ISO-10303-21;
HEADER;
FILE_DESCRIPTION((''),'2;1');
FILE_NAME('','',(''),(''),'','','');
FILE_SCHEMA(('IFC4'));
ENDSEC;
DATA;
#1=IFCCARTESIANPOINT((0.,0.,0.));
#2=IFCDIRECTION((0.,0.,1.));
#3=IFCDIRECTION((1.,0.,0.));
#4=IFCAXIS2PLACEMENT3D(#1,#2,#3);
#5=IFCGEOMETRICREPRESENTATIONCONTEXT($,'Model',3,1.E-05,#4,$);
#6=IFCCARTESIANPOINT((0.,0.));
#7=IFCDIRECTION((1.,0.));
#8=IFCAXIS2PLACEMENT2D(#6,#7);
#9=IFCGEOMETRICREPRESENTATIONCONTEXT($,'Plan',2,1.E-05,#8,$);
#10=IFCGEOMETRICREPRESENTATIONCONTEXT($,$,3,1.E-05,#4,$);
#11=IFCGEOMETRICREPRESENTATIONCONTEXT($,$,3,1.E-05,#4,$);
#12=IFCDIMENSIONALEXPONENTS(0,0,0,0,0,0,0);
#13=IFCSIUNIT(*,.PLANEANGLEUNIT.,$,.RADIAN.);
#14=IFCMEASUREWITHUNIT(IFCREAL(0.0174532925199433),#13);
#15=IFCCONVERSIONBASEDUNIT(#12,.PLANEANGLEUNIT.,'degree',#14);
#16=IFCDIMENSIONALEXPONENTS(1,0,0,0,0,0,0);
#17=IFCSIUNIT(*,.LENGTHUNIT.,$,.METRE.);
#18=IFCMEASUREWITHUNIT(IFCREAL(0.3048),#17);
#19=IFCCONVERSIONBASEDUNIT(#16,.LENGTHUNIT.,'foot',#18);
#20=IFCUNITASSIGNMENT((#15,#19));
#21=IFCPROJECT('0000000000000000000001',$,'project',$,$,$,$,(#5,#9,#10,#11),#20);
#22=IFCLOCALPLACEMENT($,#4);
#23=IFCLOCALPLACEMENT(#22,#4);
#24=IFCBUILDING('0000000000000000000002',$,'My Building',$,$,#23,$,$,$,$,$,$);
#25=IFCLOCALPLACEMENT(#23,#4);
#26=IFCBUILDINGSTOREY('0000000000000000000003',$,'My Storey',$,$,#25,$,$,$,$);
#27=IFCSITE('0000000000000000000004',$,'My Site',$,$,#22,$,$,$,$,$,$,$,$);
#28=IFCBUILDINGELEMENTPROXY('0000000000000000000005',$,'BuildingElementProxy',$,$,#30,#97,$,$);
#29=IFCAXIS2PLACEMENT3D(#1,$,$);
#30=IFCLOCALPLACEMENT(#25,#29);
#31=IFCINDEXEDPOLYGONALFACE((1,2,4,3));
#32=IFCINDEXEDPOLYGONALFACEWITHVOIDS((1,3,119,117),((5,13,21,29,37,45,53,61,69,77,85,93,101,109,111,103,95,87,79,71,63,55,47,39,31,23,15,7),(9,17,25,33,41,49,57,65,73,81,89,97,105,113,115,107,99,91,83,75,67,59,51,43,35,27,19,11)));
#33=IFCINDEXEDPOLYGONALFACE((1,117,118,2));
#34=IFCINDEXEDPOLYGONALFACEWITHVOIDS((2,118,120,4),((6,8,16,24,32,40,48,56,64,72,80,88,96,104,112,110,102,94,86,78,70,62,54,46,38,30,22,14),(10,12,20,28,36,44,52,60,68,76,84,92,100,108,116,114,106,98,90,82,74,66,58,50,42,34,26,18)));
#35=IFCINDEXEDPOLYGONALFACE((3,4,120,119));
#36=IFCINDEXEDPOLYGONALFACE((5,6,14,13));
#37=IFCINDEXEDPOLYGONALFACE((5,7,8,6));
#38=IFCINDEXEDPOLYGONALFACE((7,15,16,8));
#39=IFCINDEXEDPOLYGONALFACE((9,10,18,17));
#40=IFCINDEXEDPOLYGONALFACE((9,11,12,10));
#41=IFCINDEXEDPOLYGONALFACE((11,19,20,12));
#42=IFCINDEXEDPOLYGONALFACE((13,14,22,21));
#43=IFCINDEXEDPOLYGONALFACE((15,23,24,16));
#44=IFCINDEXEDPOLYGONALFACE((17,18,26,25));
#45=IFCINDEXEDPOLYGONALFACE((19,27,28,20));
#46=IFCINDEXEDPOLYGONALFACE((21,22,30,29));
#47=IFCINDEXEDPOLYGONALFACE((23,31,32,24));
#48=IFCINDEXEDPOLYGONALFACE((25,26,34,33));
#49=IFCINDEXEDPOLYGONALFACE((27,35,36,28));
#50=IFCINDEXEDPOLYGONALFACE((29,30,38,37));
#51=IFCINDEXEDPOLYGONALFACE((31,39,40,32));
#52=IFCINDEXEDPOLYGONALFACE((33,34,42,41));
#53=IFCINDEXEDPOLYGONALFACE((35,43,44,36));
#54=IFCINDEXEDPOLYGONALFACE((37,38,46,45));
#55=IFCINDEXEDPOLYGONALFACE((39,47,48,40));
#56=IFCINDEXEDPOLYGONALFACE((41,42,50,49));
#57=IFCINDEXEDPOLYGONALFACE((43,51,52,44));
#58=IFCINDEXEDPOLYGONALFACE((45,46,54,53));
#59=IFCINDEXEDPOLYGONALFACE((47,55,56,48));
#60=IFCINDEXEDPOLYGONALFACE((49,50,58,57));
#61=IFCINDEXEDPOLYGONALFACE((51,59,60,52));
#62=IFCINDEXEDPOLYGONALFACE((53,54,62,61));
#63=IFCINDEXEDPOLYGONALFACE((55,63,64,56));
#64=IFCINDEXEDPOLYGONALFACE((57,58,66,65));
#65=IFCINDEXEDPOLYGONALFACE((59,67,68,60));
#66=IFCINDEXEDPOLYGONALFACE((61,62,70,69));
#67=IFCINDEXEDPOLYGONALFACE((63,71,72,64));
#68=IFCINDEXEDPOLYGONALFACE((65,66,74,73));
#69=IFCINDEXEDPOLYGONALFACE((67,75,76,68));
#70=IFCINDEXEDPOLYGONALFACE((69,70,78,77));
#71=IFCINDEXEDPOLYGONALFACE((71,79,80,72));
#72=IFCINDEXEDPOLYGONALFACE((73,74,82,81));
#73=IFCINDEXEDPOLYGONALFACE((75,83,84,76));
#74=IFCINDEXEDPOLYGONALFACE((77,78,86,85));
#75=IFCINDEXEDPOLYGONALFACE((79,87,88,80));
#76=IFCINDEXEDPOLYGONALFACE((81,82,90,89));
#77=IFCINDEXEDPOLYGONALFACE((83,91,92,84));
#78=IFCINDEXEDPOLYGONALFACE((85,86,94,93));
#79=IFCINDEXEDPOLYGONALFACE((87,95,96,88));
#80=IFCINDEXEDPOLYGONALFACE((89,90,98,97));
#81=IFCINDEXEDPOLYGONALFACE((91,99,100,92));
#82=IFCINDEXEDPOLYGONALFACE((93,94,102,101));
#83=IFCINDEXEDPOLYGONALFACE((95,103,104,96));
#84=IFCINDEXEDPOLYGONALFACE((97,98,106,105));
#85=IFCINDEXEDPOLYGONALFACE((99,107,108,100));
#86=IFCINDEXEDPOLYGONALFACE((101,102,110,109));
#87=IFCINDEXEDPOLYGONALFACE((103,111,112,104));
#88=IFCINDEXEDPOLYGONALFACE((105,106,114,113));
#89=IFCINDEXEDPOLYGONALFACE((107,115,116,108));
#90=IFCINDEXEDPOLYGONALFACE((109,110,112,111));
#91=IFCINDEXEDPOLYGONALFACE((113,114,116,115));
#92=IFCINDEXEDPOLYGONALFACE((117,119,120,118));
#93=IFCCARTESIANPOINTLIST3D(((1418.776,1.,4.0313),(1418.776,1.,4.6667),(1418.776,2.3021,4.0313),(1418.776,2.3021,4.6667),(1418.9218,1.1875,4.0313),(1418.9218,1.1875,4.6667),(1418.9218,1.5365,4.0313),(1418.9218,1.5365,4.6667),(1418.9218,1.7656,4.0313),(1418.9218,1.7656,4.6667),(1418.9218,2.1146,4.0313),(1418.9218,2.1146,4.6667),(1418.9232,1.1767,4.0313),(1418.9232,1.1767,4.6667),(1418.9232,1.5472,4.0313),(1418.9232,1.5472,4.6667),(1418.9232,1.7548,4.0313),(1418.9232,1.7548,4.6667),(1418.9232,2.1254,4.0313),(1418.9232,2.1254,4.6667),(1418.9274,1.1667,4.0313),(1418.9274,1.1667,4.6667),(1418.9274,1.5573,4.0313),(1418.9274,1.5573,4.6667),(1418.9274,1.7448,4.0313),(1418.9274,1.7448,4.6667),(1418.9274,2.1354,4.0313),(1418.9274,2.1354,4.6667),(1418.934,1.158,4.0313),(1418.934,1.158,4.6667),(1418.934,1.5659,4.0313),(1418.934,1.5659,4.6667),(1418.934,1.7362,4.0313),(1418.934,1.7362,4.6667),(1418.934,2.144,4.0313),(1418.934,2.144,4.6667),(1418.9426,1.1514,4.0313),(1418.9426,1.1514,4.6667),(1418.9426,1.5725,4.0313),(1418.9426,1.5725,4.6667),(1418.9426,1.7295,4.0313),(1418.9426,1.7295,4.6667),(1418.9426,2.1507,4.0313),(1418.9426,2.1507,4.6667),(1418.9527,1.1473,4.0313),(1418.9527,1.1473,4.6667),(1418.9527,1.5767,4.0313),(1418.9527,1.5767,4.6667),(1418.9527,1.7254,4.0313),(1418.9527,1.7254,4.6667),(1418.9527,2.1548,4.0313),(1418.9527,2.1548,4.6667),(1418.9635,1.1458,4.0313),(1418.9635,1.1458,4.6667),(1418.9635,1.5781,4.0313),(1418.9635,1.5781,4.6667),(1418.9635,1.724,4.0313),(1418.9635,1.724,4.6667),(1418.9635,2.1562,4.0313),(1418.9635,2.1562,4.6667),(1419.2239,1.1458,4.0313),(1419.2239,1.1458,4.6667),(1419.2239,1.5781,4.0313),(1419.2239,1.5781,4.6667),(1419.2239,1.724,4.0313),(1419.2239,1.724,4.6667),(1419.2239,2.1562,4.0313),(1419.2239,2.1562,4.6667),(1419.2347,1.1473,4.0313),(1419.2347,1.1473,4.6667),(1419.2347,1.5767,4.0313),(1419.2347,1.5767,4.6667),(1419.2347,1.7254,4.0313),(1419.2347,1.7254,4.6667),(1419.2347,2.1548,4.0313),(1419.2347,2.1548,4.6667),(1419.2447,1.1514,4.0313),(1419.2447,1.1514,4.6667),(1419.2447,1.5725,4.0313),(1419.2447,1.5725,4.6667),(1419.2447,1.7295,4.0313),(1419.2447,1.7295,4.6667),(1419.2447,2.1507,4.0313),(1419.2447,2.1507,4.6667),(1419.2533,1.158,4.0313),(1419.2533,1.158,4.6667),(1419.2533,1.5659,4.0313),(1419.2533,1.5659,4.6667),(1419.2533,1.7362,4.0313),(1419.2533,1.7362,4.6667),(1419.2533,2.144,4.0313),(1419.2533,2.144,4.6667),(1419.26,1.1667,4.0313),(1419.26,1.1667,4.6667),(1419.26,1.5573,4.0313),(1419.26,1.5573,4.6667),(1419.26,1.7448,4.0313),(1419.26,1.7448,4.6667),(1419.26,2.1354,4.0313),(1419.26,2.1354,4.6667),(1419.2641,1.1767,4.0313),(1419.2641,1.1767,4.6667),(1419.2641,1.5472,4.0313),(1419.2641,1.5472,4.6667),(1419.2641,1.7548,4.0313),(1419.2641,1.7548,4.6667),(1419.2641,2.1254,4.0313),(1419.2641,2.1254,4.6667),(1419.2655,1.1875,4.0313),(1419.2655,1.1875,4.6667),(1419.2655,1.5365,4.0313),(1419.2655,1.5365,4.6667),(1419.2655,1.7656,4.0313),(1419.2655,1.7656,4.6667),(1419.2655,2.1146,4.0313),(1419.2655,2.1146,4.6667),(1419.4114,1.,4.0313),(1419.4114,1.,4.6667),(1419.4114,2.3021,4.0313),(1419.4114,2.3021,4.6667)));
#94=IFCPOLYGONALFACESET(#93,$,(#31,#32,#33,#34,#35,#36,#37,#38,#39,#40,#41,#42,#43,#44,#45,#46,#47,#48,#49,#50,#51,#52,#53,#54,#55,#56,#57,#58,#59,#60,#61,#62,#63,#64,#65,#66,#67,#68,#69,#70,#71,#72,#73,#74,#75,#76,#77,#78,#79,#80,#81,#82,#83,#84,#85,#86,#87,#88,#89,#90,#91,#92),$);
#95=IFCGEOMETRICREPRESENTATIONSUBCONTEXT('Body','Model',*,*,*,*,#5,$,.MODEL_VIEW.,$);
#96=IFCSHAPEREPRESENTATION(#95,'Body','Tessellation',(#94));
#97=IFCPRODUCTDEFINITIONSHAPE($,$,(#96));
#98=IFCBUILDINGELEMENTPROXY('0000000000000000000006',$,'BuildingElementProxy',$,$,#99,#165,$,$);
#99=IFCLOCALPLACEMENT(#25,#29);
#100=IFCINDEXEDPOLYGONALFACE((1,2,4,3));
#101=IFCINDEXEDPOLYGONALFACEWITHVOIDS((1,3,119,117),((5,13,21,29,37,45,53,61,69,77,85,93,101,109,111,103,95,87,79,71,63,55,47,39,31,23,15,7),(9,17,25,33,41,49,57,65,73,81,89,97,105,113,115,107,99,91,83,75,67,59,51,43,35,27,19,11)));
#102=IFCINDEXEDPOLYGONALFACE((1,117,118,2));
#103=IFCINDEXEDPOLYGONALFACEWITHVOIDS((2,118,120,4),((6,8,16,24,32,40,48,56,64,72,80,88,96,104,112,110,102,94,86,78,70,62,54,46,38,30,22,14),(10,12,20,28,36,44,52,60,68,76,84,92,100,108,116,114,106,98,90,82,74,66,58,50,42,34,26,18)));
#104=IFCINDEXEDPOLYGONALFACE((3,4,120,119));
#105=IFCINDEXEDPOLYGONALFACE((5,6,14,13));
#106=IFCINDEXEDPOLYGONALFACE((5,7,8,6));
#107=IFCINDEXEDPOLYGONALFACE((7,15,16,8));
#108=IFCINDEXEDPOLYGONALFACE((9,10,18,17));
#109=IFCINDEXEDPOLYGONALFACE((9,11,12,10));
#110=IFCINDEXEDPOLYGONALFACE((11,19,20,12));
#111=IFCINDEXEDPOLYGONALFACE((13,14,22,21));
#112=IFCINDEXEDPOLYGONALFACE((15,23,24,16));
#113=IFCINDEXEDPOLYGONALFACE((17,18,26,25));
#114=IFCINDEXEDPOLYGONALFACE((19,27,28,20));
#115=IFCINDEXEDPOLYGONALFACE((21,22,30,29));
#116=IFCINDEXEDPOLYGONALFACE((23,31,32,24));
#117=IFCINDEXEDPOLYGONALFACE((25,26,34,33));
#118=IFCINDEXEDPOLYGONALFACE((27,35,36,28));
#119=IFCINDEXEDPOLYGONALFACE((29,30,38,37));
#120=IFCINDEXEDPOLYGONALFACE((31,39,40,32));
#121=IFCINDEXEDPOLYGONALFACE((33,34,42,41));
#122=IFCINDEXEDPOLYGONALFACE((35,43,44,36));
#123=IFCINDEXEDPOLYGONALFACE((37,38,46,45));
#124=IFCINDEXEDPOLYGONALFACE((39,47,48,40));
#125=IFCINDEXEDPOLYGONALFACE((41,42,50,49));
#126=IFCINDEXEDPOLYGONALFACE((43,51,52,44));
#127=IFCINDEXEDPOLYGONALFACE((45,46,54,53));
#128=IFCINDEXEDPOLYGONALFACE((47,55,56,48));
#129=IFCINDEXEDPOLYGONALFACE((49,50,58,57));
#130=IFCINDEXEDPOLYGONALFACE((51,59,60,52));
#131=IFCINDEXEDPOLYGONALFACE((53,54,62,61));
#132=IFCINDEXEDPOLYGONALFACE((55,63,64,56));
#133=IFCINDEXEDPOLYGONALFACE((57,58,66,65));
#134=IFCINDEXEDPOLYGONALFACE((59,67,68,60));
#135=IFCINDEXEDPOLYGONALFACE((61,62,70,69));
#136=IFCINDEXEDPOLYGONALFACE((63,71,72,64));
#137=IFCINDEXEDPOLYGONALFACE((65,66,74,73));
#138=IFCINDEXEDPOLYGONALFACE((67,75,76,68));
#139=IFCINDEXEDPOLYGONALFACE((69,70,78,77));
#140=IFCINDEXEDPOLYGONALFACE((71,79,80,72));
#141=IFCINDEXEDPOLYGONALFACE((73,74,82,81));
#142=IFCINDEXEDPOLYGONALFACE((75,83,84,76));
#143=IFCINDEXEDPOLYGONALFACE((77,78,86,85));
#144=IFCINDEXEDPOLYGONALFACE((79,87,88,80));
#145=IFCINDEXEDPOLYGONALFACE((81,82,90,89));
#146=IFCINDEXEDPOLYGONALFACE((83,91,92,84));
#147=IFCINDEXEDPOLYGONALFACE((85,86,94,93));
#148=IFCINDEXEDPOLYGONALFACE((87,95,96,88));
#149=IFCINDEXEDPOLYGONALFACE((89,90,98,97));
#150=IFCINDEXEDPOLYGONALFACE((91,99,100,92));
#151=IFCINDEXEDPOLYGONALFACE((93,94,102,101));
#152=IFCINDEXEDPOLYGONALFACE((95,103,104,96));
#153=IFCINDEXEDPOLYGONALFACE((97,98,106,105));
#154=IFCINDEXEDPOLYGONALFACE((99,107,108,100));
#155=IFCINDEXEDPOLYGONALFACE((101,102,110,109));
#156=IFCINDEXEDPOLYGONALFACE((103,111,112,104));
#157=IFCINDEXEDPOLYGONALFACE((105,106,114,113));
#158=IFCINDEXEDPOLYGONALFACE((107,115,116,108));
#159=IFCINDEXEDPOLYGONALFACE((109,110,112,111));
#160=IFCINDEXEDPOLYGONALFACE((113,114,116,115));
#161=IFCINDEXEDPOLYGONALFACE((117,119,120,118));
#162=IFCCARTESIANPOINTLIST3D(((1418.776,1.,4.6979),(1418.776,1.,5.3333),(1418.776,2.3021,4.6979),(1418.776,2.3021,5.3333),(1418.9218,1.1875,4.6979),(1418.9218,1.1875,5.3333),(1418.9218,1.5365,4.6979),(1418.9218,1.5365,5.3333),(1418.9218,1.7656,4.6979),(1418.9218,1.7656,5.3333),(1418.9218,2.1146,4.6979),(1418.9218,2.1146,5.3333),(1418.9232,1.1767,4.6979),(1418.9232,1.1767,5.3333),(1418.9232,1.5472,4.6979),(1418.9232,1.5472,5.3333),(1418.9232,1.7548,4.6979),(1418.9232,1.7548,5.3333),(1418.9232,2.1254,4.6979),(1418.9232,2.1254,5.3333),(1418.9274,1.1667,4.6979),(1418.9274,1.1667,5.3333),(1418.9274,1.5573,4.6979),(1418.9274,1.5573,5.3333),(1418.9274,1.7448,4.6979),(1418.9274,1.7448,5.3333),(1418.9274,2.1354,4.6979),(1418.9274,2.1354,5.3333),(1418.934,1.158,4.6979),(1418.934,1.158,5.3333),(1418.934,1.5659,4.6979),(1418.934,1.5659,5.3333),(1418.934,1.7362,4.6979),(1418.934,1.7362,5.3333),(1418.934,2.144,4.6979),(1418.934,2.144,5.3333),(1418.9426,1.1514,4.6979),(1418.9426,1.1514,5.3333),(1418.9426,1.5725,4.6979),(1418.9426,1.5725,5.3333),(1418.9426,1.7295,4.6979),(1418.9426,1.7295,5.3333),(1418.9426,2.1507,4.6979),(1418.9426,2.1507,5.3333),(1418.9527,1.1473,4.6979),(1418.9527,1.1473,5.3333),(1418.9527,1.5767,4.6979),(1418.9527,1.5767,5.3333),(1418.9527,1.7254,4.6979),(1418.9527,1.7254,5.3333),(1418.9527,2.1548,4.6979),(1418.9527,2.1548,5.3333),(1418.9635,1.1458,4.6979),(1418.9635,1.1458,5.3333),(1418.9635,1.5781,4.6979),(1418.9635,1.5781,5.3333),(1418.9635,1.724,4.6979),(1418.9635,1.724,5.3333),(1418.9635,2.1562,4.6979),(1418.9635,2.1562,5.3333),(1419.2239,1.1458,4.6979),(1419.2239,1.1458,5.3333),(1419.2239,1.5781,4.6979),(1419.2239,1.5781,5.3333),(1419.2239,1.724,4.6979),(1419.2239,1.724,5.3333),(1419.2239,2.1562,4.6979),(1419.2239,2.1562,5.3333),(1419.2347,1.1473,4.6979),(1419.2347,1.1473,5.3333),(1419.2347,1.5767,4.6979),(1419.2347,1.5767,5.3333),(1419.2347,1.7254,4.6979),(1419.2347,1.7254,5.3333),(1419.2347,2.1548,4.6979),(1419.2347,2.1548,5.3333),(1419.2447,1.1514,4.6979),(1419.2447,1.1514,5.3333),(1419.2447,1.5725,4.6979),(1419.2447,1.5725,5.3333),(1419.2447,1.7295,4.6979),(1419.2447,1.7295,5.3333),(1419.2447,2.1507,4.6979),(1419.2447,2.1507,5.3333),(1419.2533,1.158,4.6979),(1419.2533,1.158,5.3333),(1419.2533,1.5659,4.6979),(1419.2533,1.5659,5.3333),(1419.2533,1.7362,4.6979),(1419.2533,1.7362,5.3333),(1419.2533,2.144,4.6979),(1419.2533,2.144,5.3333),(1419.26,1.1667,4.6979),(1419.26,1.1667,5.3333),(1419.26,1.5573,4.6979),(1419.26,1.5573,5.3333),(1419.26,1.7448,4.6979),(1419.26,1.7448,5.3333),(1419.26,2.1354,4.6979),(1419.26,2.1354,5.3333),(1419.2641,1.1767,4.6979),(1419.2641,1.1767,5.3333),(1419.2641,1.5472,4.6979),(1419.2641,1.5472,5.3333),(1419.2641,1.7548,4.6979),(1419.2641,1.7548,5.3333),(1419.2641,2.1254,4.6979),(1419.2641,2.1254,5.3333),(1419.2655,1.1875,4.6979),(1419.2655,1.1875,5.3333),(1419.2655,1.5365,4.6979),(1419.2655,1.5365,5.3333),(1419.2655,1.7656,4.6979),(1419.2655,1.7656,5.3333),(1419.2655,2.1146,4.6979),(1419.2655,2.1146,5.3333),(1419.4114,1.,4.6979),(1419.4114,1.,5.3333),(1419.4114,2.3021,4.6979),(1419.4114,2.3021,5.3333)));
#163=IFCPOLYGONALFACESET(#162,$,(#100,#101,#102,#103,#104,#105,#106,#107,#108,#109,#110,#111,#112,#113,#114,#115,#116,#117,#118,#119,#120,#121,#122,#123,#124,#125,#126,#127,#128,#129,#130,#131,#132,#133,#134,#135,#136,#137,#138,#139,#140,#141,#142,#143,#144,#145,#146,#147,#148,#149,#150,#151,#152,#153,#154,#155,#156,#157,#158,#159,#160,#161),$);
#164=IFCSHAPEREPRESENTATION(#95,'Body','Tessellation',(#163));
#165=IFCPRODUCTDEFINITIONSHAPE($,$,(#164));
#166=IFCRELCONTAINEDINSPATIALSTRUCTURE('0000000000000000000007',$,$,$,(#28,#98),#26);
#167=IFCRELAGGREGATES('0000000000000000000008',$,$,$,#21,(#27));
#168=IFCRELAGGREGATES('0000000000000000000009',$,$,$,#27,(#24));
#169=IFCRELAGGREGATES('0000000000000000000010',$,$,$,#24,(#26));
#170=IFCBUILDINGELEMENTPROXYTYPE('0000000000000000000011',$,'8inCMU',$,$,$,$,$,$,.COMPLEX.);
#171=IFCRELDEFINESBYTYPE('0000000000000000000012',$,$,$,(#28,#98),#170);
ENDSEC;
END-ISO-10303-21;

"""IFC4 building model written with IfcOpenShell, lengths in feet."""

from ifc_helpers import new_model, entity, si_unit, converted_unit, frame, origin_with_axes, origin_2d_with_axis, place, context, subcontext, project, spatial, line, indexed_curve, outline, extrude, source, transform, mapped, type_object, type_shapes, element, save


model = new_model("IFC4")

# Units and contexts
model_context_1 = context("Model", 3, precision=1e-05, world=origin_with_axes())
plan_context = context("Plan", 2, precision=1e-05, world=origin_2d_with_axis())
context_of_model_1 = context(None, 3, precision=1e-05, world=origin_with_axes())
context_of_model_2 = context(None, 3, precision=1e-05, world=origin_with_axes())
body_context_1 = subcontext(model_context_1, "Body", "Model", "MODEL_VIEW")
ifc_project = project(units=[converted_unit("PLANEANGLEUNIT", "degree", entity("IfcReal", 0.0174532925199433), si_unit("PLANEANGLEUNIT", "RADIAN"), dimensions=[0, 0, 0, 0, 0, 0, 0]), converted_unit("LENGTHUNIT", "foot", entity("IfcReal", 0.3048), si_unit("LENGTHUNIT", "METRE"), dimensions=[1, 0, 0, 0, 0, 0, 0])], contexts=[model_context_1, plan_context, context_of_model_1, context_of_model_2])

# Site, building, storey
site_placement = place(None, origin_with_axes())
site = spatial("IfcSite", under=ifc_project, at=site_placement, Name="My Site")
building_placement = place(site_placement, origin_with_axes())
building = spatial("IfcBuilding", under=site, at=building_placement, Name="My Building")
storey_placement = place(building_placement, origin_with_axes())
storey = spatial("IfcBuildingStorey", under=building, at=storey_placement, Name="My Storey")

# Building element proxies
building_element_proxy_type_1 = type_object("IfcBuildingElementProxyType", Name="8inCMU", PredefinedType="COMPLEX")
shared_shape_1 = source(origin_with_axes(), body_context_1, "Body", "SweptSolid", [
    extrude(outline(indexed_curve([(-0.3177, -0.651), (0.3177, -0.651), (0.3177, 0.651), (-0.3177, 0.651), (0.1719, -0.1146), (0.1719, -0.4635), (0.1705, -0.4743), (0.1663, -0.4844), (0.1597, -0.493), (0.151, -0.4996), (0.141, -0.5038), (0.1302, -0.5052), (-0.1302, -0.5052), (-0.141, -0.5038), (-0.151, -0.4996), (-0.1597, -0.493), (-0.1663, -0.4844), (-0.1705, -0.4743), (-0.1719, -0.4635), (-0.1719, -0.1146), (-0.1705, -0.1038), (-0.1663, -0.0938), (-0.1597, -0.0851), (-0.151, -0.0785), (-0.141, -0.0743), (-0.1302, -0.0729), (0.1302, -0.0729), (0.141, -0.0743), (0.151, -0.0785), (0.1597, -0.0851), (0.1663, -0.0938), (0.1705, -0.1038), (0.151, 0.0785), (0.141, 0.0743), (0.1302, 0.0729), (-0.1302, 0.0729), (-0.141, 0.0743), (-0.151, 0.0785), (-0.1597, 0.0851), (-0.1663, 0.0937), (-0.1705, 0.1038), (-0.1719, 0.1146), (-0.1719, 0.4635), (-0.1705, 0.4743), (-0.1663, 0.4844), (-0.1597, 0.493), (-0.151, 0.4996), (-0.141, 0.5038), (-0.1302, 0.5052), (0.1302, 0.5052), (0.141, 0.5038), (0.151, 0.4996), (0.1597, 0.493), (0.1663, 0.4844), (0.1705, 0.4743), (0.1719, 0.4635), (0.1719, 0.1146), (0.1705, 0.1038), (0.1663, 0.0937), (0.1597, 0.0851)], segments=[line(4, 3), line(3, 2), line(2, 1), line(1, 4)], self_intersect=False), holes=[indexed_curve([(-0.3177, -0.651), (0.3177, -0.651), (0.3177, 0.651), (-0.3177, 0.651), (0.1719, -0.1146), (0.1719, -0.4635), (0.1705, -0.4743), (0.1663, -0.4844), (0.1597, -0.493), (0.151, -0.4996), (0.141, -0.5038), (0.1302, -0.5052), (-0.1302, -0.5052), (-0.141, -0.5038), (-0.151, -0.4996), (-0.1597, -0.493), (-0.1663, -0.4844), (-0.1705, -0.4743), (-0.1719, -0.4635), (-0.1719, -0.1146), (-0.1705, -0.1038), (-0.1663, -0.0938), (-0.1597, -0.0851), (-0.151, -0.0785), (-0.141, -0.0743), (-0.1302, -0.0729), (0.1302, -0.0729), (0.141, -0.0743), (0.151, -0.0785), (0.1597, -0.0851), (0.1663, -0.0938), (0.1705, -0.1038), (0.151, 0.0785), (0.141, 0.0743), (0.1302, 0.0729), (-0.1302, 0.0729), (-0.141, 0.0743), (-0.151, 0.0785), (-0.1597, 0.0851), (-0.1663, 0.0937), (-0.1705, 0.1038), (-0.1719, 0.1146), (-0.1719, 0.4635), (-0.1705, 0.4743), (-0.1663, 0.4844), (-0.1597, 0.493), (-0.151, 0.4996), (-0.141, 0.5038), (-0.1302, 0.5052), (0.1302, 0.5052), (0.141, 0.5038), (0.151, 0.4996), (0.1597, 0.493), (0.1663, 0.4844), (0.1705, 0.4743), (0.1719, 0.4635), (0.1719, 0.1146), (0.1705, 0.1038), (0.1663, 0.0937), (0.1597, 0.0851)], segments=[line(20, 19), line(19, 18), line(18, 17), line(17, 16), line(16, 15), line(15, 14), line(14, 13), line(13, 12), line(12, 11), line(11, 10), line(10, 9), line(9, 8), line(8, 7), line(7, 6), line(6, 5), line(5, 32), line(32, 31), line(31, 30), line(30, 29), line(29, 28), line(28, 27), line(27, 26), line(26, 25), line(25, 24), line(24, 23), line(23, 22), line(22, 21), line(21, 20)], self_intersect=False), indexed_curve([(-0.3177, -0.651), (0.3177, -0.651), (0.3177, 0.651), (-0.3177, 0.651), (0.1719, -0.1146), (0.1719, -0.4635), (0.1705, -0.4743), (0.1663, -0.4844), (0.1597, -0.493), (0.151, -0.4996), (0.141, -0.5038), (0.1302, -0.5052), (-0.1302, -0.5052), (-0.141, -0.5038), (-0.151, -0.4996), (-0.1597, -0.493), (-0.1663, -0.4844), (-0.1705, -0.4743), (-0.1719, -0.4635), (-0.1719, -0.1146), (-0.1705, -0.1038), (-0.1663, -0.0938), (-0.1597, -0.0851), (-0.151, -0.0785), (-0.141, -0.0743), (-0.1302, -0.0729), (0.1302, -0.0729), (0.141, -0.0743), (0.151, -0.0785), (0.1597, -0.0851), (0.1663, -0.0938), (0.1705, -0.1038), (0.151, 0.0785), (0.141, 0.0743), (0.1302, 0.0729), (-0.1302, 0.0729), (-0.141, 0.0743), (-0.151, 0.0785), (-0.1597, 0.0851), (-0.1663, 0.0937), (-0.1705, 0.1038), (-0.1719, 0.1146), (-0.1719, 0.4635), (-0.1705, 0.4743), (-0.1663, 0.4844), (-0.1597, 0.493), (-0.151, 0.4996), (-0.141, 0.5038), (-0.1302, 0.5052), (0.1302, 0.5052), (0.141, 0.5038), (0.151, 0.4996), (0.1597, 0.493), (0.1663, 0.4844), (0.1705, 0.4743), (0.1719, 0.4635), (0.1719, 0.1146), (0.1705, 0.1038), (0.1663, 0.0937), (0.1597, 0.0851)], segments=[line(44, 43), line(43, 42), line(42, 41), line(41, 40), line(40, 39), line(39, 38), line(38, 37), line(37, 36), line(36, 35), line(35, 34), line(34, 33), line(33, 60), line(60, 59), line(59, 58), line(58, 57), line(57, 56), line(56, 55), line(55, 54), line(54, 53), line(53, 52), line(52, 51), line(51, 50), line(50, 49), line(49, 48), line(48, 47), line(47, 46), line(46, 45), line(45, 44)], self_intersect=False)]), frame((-0.651, 0.0, 0.0), z_axis=(0.0, 0.0, 1.0), x_axis=(0.0, -1.0, 0.0)), (0.0, 0.0, 1.0), 0.6354),
])
type_shapes(building_element_proxy_type_1, [shared_shape_1])
for number, where, z_axis, x_axis, name in (
    (1, (1419.0936, 2.3021, 4.0313), (0.0, 0.0, 1.0), (0.0, 1.0, 0.0), "BuildingElementProxy"),
    (2, (1419.0936, 2.3021, 4.6979), (0.0, 0.0, 1.0), (0.0, 1.0, 0.0), "BuildingElementProxy"),
):
    element("IfcBuildingElementProxy", number, at=place(storey_placement, frame(where, z_axis=z_axis, x_axis=x_axis)), inside=storey, type_object=building_element_proxy_type_1, Name=name, context=body_context_1, shape_type="MappedRepresentation", body=[
        mapped(shared_shape_1, transform((0.0, 0.0, 0.0), x_axis=(1.0, 0.0, 0.0), y_axis=(0.0, 1.0, 0.0), z_axis=(0.0, 0.0, 1.0), scale=1.0)),
    ])

save(model, "model.ifc")
